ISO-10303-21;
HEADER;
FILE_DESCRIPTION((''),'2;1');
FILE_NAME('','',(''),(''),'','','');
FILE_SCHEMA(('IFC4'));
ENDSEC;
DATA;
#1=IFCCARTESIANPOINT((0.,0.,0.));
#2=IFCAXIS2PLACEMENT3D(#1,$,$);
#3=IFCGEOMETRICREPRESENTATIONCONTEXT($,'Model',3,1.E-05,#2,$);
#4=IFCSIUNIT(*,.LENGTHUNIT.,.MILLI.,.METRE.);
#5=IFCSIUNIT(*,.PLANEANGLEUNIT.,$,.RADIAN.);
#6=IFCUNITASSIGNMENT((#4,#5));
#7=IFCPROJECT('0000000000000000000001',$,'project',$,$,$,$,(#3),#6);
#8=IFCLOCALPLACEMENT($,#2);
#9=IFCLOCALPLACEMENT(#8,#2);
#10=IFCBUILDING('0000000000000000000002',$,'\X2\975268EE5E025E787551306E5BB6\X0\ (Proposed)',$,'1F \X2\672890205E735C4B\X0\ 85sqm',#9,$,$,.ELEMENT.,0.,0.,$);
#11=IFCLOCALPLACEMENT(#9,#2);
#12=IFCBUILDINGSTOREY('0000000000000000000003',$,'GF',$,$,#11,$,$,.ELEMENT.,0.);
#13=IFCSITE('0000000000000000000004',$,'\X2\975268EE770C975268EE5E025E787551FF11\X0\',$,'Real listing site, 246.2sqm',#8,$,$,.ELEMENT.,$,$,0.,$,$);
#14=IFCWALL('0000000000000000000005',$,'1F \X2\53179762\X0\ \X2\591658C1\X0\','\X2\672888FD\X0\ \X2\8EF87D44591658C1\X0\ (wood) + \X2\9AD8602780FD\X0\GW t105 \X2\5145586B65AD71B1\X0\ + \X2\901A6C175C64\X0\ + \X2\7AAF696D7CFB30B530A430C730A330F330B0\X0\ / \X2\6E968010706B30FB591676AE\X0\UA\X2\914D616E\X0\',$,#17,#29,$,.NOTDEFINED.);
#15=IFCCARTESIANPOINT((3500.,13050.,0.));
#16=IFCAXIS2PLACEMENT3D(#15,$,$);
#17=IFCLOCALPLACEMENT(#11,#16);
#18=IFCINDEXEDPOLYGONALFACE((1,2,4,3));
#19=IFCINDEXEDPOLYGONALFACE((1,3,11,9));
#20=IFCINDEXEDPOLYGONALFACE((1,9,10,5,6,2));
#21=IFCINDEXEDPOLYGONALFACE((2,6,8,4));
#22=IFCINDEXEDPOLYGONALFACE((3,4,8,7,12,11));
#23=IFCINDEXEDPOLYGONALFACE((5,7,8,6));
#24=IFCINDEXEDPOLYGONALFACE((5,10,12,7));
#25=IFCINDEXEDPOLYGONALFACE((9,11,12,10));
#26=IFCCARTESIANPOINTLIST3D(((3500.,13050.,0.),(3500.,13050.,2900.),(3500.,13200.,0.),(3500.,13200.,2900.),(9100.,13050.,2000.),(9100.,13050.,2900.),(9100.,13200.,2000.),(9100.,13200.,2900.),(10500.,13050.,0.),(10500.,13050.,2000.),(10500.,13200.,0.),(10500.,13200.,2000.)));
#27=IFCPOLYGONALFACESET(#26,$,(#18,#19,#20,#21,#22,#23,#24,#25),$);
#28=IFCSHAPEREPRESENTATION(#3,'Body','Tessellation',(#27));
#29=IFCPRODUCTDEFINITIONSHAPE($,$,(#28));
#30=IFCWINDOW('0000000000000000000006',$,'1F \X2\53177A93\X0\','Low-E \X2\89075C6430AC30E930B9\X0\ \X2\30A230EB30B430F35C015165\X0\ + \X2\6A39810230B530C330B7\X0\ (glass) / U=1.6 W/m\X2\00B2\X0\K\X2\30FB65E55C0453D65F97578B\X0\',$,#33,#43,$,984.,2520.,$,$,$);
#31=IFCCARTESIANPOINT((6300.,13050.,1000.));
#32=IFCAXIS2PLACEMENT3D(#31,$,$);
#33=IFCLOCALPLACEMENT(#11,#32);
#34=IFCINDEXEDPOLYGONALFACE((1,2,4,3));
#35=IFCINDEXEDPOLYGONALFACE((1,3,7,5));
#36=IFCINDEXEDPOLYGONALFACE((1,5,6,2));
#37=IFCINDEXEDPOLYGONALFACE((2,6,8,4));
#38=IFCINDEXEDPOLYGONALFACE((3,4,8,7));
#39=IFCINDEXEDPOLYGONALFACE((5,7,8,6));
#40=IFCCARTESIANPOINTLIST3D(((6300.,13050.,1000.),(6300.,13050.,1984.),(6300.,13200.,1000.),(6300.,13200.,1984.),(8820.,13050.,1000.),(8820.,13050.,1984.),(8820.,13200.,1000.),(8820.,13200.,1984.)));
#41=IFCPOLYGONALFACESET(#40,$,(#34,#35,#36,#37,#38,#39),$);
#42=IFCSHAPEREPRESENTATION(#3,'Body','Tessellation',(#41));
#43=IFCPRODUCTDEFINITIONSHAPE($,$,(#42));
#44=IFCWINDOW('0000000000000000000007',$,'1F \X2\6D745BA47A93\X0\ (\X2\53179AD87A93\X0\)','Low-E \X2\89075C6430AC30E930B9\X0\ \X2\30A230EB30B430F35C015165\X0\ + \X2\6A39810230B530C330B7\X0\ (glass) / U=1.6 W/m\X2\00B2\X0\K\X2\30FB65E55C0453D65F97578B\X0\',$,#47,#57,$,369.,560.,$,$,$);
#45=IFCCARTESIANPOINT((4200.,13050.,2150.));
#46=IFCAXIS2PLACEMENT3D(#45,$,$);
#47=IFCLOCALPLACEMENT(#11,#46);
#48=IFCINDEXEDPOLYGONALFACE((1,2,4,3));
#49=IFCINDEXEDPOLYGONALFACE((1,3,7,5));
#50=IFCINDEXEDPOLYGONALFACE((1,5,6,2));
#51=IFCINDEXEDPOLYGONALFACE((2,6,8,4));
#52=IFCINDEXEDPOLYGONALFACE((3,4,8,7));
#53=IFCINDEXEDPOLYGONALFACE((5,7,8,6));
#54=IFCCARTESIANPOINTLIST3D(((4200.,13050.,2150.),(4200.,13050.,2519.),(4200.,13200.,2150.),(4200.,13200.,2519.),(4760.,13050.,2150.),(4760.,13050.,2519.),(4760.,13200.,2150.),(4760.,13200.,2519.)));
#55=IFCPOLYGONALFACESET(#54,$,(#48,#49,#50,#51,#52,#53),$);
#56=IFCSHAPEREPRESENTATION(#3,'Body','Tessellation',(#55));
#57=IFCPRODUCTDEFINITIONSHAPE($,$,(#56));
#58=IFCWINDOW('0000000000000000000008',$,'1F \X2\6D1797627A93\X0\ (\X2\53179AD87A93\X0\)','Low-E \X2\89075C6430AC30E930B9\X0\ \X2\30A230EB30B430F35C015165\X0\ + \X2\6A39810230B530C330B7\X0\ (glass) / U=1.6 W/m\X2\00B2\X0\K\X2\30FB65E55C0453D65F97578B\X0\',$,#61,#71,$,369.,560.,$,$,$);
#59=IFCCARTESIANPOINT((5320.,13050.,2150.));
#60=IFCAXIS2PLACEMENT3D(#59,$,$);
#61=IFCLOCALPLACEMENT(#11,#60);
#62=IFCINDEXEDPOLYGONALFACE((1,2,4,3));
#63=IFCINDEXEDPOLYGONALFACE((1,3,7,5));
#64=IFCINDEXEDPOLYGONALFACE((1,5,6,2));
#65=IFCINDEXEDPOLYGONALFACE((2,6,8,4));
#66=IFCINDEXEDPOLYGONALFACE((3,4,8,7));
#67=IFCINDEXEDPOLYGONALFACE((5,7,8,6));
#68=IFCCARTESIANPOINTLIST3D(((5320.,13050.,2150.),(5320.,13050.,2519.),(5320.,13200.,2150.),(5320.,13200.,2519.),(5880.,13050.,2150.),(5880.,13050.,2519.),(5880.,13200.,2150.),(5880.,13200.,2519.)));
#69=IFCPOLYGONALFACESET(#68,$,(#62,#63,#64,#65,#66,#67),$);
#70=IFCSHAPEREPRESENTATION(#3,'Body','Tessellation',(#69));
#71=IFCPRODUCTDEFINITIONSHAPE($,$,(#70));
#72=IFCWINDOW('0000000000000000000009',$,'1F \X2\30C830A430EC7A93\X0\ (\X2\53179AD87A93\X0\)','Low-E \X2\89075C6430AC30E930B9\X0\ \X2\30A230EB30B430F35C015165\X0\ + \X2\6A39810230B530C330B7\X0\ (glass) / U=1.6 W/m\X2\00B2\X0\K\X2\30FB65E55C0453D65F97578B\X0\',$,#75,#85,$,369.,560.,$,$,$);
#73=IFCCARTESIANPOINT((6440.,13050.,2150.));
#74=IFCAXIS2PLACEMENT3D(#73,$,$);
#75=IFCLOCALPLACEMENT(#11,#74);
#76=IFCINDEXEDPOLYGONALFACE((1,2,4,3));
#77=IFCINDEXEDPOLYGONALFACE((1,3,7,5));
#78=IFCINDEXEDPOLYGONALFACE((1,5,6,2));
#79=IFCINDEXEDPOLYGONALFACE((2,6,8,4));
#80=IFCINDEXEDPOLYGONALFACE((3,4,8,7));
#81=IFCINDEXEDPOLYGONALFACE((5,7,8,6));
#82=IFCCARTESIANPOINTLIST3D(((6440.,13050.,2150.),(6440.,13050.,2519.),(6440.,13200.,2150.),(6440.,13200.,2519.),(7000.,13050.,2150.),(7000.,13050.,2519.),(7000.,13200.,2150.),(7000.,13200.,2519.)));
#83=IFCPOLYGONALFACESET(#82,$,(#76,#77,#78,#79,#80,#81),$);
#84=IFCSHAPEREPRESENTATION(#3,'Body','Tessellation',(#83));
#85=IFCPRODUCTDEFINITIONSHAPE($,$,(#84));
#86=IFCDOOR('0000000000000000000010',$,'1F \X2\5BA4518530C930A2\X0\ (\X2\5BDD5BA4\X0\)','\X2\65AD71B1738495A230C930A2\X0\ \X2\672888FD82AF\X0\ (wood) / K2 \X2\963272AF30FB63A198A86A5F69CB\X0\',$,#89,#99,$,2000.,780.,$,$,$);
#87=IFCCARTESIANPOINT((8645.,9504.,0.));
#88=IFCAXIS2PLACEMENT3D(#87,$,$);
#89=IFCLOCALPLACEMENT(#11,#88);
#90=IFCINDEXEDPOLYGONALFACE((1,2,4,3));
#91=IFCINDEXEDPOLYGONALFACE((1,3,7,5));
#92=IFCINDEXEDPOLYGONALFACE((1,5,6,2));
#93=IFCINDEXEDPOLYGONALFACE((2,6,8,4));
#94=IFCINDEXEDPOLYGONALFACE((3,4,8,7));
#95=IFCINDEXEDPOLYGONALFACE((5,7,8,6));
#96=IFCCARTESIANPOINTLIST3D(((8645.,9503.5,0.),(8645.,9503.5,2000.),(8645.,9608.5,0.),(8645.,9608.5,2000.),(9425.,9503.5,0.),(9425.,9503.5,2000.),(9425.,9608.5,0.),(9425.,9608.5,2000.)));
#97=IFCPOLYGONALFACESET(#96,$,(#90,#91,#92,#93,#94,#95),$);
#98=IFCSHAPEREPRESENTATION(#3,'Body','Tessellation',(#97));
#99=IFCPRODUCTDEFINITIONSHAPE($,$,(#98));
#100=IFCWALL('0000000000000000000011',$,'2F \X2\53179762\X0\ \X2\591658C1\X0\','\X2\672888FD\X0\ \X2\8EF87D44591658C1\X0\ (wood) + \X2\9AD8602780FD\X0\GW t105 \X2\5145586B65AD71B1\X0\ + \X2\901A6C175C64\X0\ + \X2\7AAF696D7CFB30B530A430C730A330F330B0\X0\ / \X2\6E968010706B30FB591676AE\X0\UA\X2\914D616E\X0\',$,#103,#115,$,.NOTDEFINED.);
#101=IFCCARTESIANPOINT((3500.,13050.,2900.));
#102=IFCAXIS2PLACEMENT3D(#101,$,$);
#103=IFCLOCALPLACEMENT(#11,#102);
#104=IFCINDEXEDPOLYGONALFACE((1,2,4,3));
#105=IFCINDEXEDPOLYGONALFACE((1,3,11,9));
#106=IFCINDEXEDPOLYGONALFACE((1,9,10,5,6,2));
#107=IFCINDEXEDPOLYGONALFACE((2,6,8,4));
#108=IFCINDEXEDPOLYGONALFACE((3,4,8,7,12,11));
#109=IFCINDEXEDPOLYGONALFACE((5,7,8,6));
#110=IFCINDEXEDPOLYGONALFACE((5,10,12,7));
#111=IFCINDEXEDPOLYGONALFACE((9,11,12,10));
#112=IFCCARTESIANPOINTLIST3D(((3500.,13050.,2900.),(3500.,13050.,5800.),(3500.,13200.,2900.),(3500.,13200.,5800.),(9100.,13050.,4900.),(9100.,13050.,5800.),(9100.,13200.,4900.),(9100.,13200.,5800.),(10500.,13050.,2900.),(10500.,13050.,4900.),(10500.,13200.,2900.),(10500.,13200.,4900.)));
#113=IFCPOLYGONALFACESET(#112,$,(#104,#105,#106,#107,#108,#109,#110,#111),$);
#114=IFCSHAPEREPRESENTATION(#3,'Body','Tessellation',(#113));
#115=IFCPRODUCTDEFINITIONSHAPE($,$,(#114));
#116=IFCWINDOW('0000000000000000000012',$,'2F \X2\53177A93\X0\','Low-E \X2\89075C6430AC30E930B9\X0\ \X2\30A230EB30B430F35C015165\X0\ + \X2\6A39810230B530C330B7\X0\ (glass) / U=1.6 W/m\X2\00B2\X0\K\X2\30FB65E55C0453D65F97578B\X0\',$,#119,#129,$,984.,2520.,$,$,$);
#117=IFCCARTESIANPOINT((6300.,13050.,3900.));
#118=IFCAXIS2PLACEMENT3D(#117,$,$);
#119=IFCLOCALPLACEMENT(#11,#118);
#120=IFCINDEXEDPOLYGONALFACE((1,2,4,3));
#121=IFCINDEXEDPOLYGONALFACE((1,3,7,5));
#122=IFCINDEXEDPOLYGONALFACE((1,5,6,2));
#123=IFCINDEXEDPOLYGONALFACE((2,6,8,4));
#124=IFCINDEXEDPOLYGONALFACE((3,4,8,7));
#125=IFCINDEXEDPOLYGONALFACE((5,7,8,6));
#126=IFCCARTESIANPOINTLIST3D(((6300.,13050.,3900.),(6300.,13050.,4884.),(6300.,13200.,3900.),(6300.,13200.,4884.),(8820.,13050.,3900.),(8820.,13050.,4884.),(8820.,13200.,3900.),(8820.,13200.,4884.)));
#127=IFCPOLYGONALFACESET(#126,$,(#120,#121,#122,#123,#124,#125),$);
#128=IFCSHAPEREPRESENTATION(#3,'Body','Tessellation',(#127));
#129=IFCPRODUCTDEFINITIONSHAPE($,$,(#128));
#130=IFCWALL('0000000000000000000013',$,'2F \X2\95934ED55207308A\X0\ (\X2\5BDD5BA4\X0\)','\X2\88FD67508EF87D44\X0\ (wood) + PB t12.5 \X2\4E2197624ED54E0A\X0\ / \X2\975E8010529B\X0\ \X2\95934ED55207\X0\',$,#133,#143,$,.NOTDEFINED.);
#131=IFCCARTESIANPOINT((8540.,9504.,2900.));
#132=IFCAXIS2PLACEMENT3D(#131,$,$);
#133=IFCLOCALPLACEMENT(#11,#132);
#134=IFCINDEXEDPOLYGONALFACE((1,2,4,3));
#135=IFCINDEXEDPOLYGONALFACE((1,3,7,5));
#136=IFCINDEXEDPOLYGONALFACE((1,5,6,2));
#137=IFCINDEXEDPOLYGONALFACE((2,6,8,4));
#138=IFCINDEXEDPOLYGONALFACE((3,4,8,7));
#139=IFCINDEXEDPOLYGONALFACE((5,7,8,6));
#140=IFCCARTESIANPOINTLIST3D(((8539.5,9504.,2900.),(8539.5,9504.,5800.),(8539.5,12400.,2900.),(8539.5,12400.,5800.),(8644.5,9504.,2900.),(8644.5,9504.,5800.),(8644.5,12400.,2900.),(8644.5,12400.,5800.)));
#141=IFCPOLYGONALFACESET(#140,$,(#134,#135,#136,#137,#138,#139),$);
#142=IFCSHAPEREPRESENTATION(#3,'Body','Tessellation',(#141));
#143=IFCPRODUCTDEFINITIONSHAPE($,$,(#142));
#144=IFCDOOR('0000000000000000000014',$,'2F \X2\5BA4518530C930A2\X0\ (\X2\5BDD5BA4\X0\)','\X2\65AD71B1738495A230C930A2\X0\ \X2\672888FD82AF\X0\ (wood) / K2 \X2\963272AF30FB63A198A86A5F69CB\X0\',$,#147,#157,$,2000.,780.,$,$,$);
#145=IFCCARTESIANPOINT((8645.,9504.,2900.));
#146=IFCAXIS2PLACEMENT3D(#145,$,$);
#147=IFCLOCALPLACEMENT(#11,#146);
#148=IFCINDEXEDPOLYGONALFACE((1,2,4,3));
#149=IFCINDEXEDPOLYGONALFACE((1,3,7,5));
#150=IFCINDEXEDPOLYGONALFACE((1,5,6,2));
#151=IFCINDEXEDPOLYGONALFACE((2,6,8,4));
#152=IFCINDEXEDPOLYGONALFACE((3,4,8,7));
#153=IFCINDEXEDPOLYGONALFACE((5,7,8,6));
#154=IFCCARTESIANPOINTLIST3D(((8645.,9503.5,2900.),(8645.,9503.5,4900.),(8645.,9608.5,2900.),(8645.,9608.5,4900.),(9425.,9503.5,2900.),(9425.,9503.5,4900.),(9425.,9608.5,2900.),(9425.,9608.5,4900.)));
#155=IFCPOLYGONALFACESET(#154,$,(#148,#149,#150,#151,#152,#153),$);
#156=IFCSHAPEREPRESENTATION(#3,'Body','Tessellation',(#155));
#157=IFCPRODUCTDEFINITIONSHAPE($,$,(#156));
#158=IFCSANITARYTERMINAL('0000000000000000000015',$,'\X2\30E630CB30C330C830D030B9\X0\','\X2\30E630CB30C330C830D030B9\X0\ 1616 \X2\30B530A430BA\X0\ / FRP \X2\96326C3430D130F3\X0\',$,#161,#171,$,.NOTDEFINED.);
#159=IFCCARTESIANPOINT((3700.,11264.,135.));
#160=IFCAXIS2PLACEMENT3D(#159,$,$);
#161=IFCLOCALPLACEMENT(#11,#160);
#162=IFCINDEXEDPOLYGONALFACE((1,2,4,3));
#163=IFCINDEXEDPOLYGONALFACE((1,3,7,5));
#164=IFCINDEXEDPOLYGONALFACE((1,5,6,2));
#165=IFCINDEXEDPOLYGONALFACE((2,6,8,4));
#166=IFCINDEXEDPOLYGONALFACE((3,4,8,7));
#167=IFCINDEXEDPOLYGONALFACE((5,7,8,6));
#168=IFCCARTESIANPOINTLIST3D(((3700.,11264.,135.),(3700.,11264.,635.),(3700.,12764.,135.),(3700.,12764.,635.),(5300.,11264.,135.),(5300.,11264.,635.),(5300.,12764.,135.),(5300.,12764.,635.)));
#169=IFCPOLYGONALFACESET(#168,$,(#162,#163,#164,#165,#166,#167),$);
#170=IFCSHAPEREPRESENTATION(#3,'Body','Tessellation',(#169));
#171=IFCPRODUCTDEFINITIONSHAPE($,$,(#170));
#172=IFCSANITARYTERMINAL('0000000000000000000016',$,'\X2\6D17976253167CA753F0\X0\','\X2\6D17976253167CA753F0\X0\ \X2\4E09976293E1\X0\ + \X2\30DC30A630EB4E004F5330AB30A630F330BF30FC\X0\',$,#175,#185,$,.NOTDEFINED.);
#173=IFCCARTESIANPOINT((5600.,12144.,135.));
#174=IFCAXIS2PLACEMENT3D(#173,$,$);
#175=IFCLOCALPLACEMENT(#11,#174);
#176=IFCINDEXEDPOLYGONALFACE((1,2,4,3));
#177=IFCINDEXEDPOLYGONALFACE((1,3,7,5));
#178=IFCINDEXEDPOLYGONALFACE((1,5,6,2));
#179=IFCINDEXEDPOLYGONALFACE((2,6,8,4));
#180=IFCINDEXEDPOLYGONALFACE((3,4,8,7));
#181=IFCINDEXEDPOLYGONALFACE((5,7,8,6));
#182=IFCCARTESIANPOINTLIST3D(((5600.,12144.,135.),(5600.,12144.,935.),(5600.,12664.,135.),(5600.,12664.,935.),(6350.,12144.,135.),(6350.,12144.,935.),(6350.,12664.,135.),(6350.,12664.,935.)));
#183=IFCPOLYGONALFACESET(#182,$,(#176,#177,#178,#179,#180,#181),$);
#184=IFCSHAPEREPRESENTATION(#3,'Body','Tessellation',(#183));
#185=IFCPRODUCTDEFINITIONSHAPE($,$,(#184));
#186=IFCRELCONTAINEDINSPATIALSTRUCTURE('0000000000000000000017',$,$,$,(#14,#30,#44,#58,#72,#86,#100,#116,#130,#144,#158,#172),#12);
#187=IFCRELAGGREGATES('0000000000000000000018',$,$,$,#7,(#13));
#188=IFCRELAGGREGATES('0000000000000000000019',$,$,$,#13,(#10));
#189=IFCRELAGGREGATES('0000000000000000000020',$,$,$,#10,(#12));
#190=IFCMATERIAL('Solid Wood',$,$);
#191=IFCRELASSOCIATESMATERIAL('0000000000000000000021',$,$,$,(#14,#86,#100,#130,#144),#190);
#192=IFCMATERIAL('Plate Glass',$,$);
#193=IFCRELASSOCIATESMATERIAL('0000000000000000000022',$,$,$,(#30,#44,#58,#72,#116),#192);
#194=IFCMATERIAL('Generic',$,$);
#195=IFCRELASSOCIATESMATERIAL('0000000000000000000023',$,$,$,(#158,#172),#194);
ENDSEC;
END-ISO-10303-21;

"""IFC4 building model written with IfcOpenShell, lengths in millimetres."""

from ifc_helpers import new_model, si_unit, frame, frame_2d, origin, place, context, project, spatial, rectangle, extrude, material, element, fill, save


model = new_model("IFC4")

# Units and contexts
model_context = context("Model", 3, precision=1e-05, world=origin())
ifc_project = project(units=[si_unit("LENGTHUNIT", "METRE", prefix="MILLI"), si_unit("PLANEANGLEUNIT", "RADIAN")], contexts=[model_context])

# Site, building, storey
site_placement = place(None, origin())
site = spatial("IfcSite", under=ifc_project, at=site_placement, Name="青森県青森市幸畑１", ObjectType="Real listing site, 246.2sqm", CompositionType="ELEMENT", RefElevation=0.0)
building_placement = place(site_placement, origin())
building = spatial("IfcBuilding", under=site, at=building_placement, Name="青森市幸畑の家 (Proposed)", ObjectType="1F 木造平屋 85sqm", CompositionType="ELEMENT", ElevationOfRefHeight=0.0, ElevationOfTerrain=0.0)
storey_placement = place(building_placement, origin())
storey = spatial("IfcBuildingStorey", under=building, at=storey_placement, Name="GF", CompositionType="ELEMENT", Elevation=0.0)

# Wall, openings, windows
ifc_material_1 = material(Name="Solid Wood")
wall_1_placement = place(storey_placement, frame((3500.0, 13050.0, 0.0)))
wall_1 = element("IfcWall", 1, at=wall_1_placement, inside=storey, material=ifc_material_1, Name="1F 北面 外壁", Description="木製 軸組外壁 (wood) + 高性能GW t105 充填断熱 + 通気層 + 窯業系サイディング / 準耐火・外皮UA配慮", PredefinedType="NOTDEFINED", context=model_context, shape_type="SweptSolid", body=[
    extrude(rectangle(XDim=7000.0, YDim=150.0, at=frame_2d((3500.0, 75.0))), frame((3500.0, 13050.0, 0.0)), (0.0, 0.0, 1.0), 2900.0),
])
opening_1_placement = place(storey_placement, frame((6300.0, 13050.0, 1000.0)))
opening_1 = element("IfcOpeningElement", 2, at=opening_1_placement, cuts=wall_1, PredefinedType="NOTDEFINED", context=model_context, shape_type="SweptSolid", body=[
    extrude(rectangle(XDim=2520.0, YDim=150.0, at=frame_2d((1260.0, 75.0))), frame((6300.0, 13050.0, 1000.0)), (0.0, 0.0, 1.0), 984.0),
])
opening_2_placement = place(storey_placement, frame((4200.0, 13050.0, 2150.0)))
opening_2 = element("IfcOpeningElement", 3, at=opening_2_placement, cuts=wall_1, PredefinedType="NOTDEFINED", context=model_context, shape_type="SweptSolid", body=[
    extrude(rectangle(XDim=560.0, YDim=150.0, at=frame_2d((280.0, 75.0))), frame((4200.0, 13050.0, 2150.0)), (0.0, 0.0, 1.0), 369.0),
])
opening_3_placement = place(storey_placement, frame((5320.0, 13050.0, 2150.0)))
opening_3 = element("IfcOpeningElement", 4, at=opening_3_placement, cuts=wall_1, PredefinedType="NOTDEFINED", context=model_context, shape_type="SweptSolid", body=[
    extrude(rectangle(XDim=560.0, YDim=150.0, at=frame_2d((280.0, 75.0))), frame((5320.0, 13050.0, 2150.0)), (0.0, 0.0, 1.0), 369.0),
])
opening_4_placement = place(storey_placement, frame((6440.0, 13050.0, 2150.0)))
opening_4 = element("IfcOpeningElement", 5, at=opening_4_placement, cuts=wall_1, PredefinedType="NOTDEFINED", context=model_context, shape_type="SweptSolid", body=[
    extrude(rectangle(XDim=560.0, YDim=150.0, at=frame_2d((280.0, 75.0))), frame((6440.0, 13050.0, 2150.0)), (0.0, 0.0, 1.0), 369.0),
])
ifc_material_2 = material(Name="Plate Glass")
window_1_placement = place(storey_placement, frame((6300.0, 13050.0, 1000.0)))
window_1 = element("IfcWindow", 6, at=window_1_placement, inside=storey, material=ifc_material_2, Name="1F 北窓", Description="Low-E 複層ガラス アルゴン封入 + 樹脂サッシ (glass) / U=1.6 W/m²K・日射取得型", OverallHeight=984.0, OverallWidth=2520.0, context=model_context, shape_type="SweptSolid", body=[
    extrude(rectangle(XDim=2520.0, YDim=150.0, at=frame_2d((1260.0, 75.0))), frame((6300.0, 13050.0, 1000.0)), (0.0, 0.0, 1.0), 984.0),
])
fill(opening_1, window_1)
window_2_placement = place(storey_placement, frame((4200.0, 13050.0, 2150.0)))
window_2 = element("IfcWindow", 7, at=window_2_placement, inside=storey, material=ifc_material_2, Name="1F 浴室窓 (北高窓)", Description="Low-E 複層ガラス アルゴン封入 + 樹脂サッシ (glass) / U=1.6 W/m²K・日射取得型", OverallHeight=369.0, OverallWidth=560.0, context=model_context, shape_type="SweptSolid", body=[
    extrude(rectangle(XDim=560.0, YDim=150.0, at=frame_2d((280.0, 75.0))), frame((4200.0, 13050.0, 2150.0)), (0.0, 0.0, 1.0), 369.0),
])
fill(opening_2, window_2)
window_3_placement = place(storey_placement, frame((5320.0, 13050.0, 2150.0)))
window_3 = element("IfcWindow", 8, at=window_3_placement, inside=storey, material=ifc_material_2, Name="1F 洗面窓 (北高窓)", Description="Low-E 複層ガラス アルゴン封入 + 樹脂サッシ (glass) / U=1.6 W/m²K・日射取得型", OverallHeight=369.0, OverallWidth=560.0, context=model_context, shape_type="SweptSolid", body=[
    extrude(rectangle(XDim=560.0, YDim=150.0, at=frame_2d((280.0, 75.0))), frame((5320.0, 13050.0, 2150.0)), (0.0, 0.0, 1.0), 369.0),
])
fill(opening_3, window_3)
window_4_placement = place(storey_placement, frame((6440.0, 13050.0, 2150.0)))
window_4 = element("IfcWindow", 9, at=window_4_placement, inside=storey, material=ifc_material_2, Name="1F トイレ窓 (北高窓)", Description="Low-E 複層ガラス アルゴン封入 + 樹脂サッシ (glass) / U=1.6 W/m²K・日射取得型", OverallHeight=369.0, OverallWidth=560.0, context=model_context, shape_type="SweptSolid", body=[
    extrude(rectangle(XDim=560.0, YDim=150.0, at=frame_2d((280.0, 75.0))), frame((6440.0, 13050.0, 2150.0)), (0.0, 0.0, 1.0), 369.0),
])
fill(opening_4, window_4)

# Door
door_1_placement = place(storey_placement, frame((8645.0, 9504.0, 0.0)))
element("IfcDoor", 10, at=door_1_placement, inside=storey, material=ifc_material_1, Name="1F 室内ドア (寝室)", Description="断熱玄関ドア 木製芯 (wood) / K2 防犯・採風機構", OverallHeight=2000.0, OverallWidth=780.0, context=model_context, shape_type="SweptSolid", body=[
    extrude(rectangle(XDim=780.0, YDim=105.0, at=frame_2d((390.0, 52.0))), frame((8645.0, 9504.0, 0.0)), (0.0, 0.0, 1.0), 2000.0),
])

# Wall, opening, window
wall_2_placement = place(storey_placement, frame((3500.0, 13050.0, 2900.0)))
wall_2 = element("IfcWall", 11, at=wall_2_placement, inside=storey, material=ifc_material_1, Name="2F 北面 外壁", Description="木製 軸組外壁 (wood) + 高性能GW t105 充填断熱 + 通気層 + 窯業系サイディング / 準耐火・外皮UA配慮", PredefinedType="NOTDEFINED", context=model_context, shape_type="SweptSolid", body=[
    extrude(rectangle(XDim=7000.0, YDim=150.0, at=frame_2d((3500.0, 75.0))), frame((3500.0, 13050.0, 2900.0)), (0.0, 0.0, 1.0), 2900.0),
])
opening_5_placement = place(storey_placement, frame((6300.0, 13050.0, 3900.0)))
opening_5 = element("IfcOpeningElement", 12, at=opening_5_placement, cuts=wall_2, PredefinedType="NOTDEFINED", context=model_context, shape_type="SweptSolid", body=[
    extrude(rectangle(XDim=2520.0, YDim=150.0, at=frame_2d((1260.0, 75.0))), frame((6300.0, 13050.0, 3900.0)), (0.0, 0.0, 1.0), 984.0),
])
window_5_placement = place(storey_placement, frame((6300.0, 13050.0, 3900.0)))
window_5 = element("IfcWindow", 13, at=window_5_placement, inside=storey, material=ifc_material_2, Name="2F 北窓", Description="Low-E 複層ガラス アルゴン封入 + 樹脂サッシ (glass) / U=1.6 W/m²K・日射取得型", OverallHeight=984.0, OverallWidth=2520.0, context=model_context, shape_type="SweptSolid", body=[
    extrude(rectangle(XDim=2520.0, YDim=150.0, at=frame_2d((1260.0, 75.0))), frame((6300.0, 13050.0, 3900.0)), (0.0, 0.0, 1.0), 984.0),
])
fill(opening_5, window_5)

# Wall
wall_3_placement = place(storey_placement, frame((8540.0, 9504.0, 2900.0)))
element("IfcWall", 14, at=wall_3_placement, inside=storey, material=ifc_material_1, Name="2F 間仕切り (寝室)", Description="製材軸組 (wood) + PB t12.5 両面仕上 / 非耐力 間仕切", PredefinedType="NOTDEFINED", context=model_context, shape_type="SweptSolid", body=[
    extrude(rectangle(XDim=105.0, YDim=2896.0, at=frame_2d((52.0, 1448.0))), frame((8540.0, 9504.0, 2900.0)), (0.0, 0.0, 1.0), 2900.0),
])

# Door
door_2_placement = place(storey_placement, frame((8645.0, 9504.0, 2900.0)))
element("IfcDoor", 15, at=door_2_placement, inside=storey, material=ifc_material_1, Name="2F 室内ドア (寝室)", Description="断熱玄関ドア 木製芯 (wood) / K2 防犯・採風機構", OverallHeight=2000.0, OverallWidth=780.0, context=model_context, shape_type="SweptSolid", body=[
    extrude(rectangle(XDim=780.0, YDim=105.0, at=frame_2d((390.0, 52.0))), frame((8645.0, 9504.0, 2900.0)), (0.0, 0.0, 1.0), 2000.0),
])

# Sanitary terminals
ifc_material_3 = material(Name="Generic")
sanitary_terminal_1_placement = place(storey_placement, frame((3700.0, 11264.0, 135.0)))
element("IfcSanitaryTerminal", 16, at=sanitary_terminal_1_placement, inside=storey, material=ifc_material_3, Name="ユニットバス", Description="ユニットバス 1616 サイズ / FRP 防水パン", PredefinedType="NOTDEFINED", context=model_context, shape_type="SweptSolid", body=[
    extrude(rectangle(XDim=1600.0, YDim=1500.0, at=frame_2d((800.0, 750.0))), frame((3700.0, 11264.0, 135.0)), (0.0, 0.0, 1.0), 500.0),
])
sanitary_terminal_2_placement = place(storey_placement, frame((5600.0, 12144.0, 135.0)))
element("IfcSanitaryTerminal", 17, at=sanitary_terminal_2_placement, inside=storey, material=ifc_material_3, Name="洗面化粧台", Description="洗面化粧台 三面鏡 + ボウル一体カウンター", PredefinedType="NOTDEFINED", context=model_context, shape_type="SweptSolid", body=[
    extrude(rectangle(XDim=750.0, YDim=520.0, at=frame_2d((375.0, 260.0))), frame((5600.0, 12144.0, 135.0)), (0.0, 0.0, 1.0), 800.0),
])

save(model, "model.ifc")
